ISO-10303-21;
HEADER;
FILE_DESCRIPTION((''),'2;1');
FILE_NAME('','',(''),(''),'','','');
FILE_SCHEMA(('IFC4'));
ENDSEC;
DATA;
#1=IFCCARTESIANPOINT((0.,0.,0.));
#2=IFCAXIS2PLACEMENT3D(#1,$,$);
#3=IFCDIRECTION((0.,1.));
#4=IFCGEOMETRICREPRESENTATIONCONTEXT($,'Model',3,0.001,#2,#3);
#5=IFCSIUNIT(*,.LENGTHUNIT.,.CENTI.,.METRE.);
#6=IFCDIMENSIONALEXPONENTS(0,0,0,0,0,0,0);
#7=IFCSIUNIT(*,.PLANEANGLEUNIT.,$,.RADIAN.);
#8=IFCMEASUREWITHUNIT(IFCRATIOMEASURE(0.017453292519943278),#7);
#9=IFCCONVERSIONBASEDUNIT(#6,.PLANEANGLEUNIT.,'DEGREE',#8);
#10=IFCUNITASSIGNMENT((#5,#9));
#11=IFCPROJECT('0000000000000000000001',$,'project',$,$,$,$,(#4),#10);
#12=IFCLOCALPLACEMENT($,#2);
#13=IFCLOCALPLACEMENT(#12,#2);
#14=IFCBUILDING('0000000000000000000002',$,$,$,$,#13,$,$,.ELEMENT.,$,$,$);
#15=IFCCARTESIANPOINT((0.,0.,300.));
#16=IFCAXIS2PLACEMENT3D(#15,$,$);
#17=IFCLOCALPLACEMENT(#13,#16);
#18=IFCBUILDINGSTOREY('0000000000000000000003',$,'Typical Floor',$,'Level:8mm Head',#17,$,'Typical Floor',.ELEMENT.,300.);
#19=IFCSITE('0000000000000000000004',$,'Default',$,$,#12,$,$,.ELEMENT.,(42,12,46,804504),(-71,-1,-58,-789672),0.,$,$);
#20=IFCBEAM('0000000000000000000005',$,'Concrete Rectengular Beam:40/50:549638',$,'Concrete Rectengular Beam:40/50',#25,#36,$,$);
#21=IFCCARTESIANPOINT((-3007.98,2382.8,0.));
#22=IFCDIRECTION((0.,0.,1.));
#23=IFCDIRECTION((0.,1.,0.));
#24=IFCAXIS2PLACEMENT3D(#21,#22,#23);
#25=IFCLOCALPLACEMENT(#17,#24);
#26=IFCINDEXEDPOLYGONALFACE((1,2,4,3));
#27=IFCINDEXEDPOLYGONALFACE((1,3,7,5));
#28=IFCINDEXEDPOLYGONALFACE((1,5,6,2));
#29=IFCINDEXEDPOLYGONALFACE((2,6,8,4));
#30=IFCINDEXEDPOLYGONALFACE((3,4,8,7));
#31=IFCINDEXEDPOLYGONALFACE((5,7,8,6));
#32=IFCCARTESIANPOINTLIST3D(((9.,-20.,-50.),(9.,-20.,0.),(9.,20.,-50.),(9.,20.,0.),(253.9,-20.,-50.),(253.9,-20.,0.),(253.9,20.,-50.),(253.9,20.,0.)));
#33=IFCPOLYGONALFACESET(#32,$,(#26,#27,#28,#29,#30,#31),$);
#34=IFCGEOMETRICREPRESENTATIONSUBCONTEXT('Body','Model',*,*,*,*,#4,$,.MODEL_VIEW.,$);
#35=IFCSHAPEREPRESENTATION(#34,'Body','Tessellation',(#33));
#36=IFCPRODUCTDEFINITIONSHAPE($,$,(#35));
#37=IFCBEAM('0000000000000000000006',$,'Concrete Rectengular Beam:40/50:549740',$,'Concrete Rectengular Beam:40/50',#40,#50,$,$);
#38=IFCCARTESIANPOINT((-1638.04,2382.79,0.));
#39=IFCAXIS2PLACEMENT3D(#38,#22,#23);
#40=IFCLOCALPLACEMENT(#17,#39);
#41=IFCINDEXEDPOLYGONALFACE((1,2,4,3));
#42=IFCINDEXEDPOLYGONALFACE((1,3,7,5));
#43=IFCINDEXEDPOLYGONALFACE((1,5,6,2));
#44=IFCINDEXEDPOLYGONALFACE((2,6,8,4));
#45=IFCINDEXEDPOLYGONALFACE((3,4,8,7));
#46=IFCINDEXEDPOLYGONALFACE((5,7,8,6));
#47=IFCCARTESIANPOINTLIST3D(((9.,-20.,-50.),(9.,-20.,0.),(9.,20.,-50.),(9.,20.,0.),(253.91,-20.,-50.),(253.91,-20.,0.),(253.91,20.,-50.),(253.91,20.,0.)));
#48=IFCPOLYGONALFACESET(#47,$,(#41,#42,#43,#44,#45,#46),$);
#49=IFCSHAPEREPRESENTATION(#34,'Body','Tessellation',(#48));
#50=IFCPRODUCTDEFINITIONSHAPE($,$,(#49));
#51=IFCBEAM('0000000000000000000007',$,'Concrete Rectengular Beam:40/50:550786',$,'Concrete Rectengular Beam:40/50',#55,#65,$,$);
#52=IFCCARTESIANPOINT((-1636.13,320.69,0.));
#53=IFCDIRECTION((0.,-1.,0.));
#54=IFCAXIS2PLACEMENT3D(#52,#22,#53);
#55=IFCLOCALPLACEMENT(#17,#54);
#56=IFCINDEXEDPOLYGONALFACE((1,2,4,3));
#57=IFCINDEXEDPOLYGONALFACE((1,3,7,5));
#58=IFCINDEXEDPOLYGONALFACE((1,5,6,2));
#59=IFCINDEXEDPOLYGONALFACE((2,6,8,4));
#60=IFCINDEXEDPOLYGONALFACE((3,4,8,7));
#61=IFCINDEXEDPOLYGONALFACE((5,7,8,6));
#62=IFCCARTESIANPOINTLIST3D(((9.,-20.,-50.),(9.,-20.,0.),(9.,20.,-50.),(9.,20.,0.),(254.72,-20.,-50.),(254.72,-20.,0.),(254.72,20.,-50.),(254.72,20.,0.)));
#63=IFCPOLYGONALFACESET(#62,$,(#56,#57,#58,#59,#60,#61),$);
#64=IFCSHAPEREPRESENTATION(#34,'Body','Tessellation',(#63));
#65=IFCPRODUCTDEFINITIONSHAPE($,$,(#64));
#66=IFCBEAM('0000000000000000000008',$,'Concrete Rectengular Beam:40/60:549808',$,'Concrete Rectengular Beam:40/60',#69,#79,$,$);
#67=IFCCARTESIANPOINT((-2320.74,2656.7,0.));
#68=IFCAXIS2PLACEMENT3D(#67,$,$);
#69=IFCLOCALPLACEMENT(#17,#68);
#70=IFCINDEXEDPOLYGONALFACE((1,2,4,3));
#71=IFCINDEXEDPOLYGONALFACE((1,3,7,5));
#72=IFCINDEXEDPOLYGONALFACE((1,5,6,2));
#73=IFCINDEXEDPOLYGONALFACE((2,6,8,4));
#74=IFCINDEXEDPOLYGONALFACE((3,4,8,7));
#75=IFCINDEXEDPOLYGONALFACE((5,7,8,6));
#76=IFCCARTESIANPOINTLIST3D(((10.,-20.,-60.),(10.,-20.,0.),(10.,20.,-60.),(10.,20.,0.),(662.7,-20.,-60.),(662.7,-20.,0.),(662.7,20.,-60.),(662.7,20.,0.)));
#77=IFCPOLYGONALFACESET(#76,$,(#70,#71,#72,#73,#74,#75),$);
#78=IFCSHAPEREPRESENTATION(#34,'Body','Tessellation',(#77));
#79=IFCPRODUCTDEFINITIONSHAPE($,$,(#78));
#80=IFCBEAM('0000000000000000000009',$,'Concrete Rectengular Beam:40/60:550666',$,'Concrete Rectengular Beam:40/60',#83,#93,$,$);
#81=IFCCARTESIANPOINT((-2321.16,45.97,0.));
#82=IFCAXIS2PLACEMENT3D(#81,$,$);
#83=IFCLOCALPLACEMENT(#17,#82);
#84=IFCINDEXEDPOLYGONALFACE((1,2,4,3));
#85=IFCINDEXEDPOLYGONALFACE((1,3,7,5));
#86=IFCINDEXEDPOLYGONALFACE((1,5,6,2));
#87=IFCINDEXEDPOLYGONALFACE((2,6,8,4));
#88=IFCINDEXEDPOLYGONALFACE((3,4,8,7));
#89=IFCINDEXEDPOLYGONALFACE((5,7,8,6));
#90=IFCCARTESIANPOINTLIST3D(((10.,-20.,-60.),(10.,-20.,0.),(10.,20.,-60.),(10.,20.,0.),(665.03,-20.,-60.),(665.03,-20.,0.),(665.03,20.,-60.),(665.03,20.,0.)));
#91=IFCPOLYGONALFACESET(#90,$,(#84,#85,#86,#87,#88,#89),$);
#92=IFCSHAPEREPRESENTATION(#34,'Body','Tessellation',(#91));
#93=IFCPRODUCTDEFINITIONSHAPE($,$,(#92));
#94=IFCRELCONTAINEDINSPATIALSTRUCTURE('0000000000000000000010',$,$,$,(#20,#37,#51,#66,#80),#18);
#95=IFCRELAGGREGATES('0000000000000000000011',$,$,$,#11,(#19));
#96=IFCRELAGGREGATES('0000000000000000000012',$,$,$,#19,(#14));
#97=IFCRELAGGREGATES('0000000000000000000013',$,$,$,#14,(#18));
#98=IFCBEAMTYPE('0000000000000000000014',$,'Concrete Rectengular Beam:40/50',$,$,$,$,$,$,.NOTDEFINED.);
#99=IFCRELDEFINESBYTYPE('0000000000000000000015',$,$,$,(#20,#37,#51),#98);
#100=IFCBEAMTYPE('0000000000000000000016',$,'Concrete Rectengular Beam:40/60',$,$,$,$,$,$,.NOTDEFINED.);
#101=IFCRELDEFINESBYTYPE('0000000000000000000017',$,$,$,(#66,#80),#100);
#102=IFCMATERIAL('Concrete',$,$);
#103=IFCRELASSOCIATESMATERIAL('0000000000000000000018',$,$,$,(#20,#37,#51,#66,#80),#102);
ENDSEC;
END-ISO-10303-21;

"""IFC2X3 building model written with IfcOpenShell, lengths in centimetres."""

from ifc_helpers import new_model, entity, si_unit, converted_unit, direction, frame, frame_2d, origin, origin_2d_with_axis, place, context, subcontext, project, spatial, rectangle, extrude, material, type_object, element, save


model = new_model("IFC2X3")

# Units and contexts
model_context = context("Model", 3, precision=0.001, world=origin(), true_north=direction((0.0, 1.0)))
body_context = subcontext(model_context, "Body", "Model", "MODEL_VIEW")
ifc_project = project(units=[si_unit("LENGTHUNIT", "METRE", prefix="CENTI"), converted_unit("PLANEANGLEUNIT", "DEGREE", entity("IfcRatioMeasure", 0.017453292519943278), si_unit("PLANEANGLEUNIT", "RADIAN"), dimensions=[0, 0, 0, 0, 0, 0, 0])], contexts=[model_context])

# Site, building, storey
site_placement = place(None, origin())
site = spatial("IfcSite", under=ifc_project, at=site_placement, Name="Default", CompositionType="ELEMENT", RefLatitude=(42, 12, 46, 804504), RefLongitude=(-71, -1, -58, -789672), RefElevation=0.0)
building_placement = place(site_placement, origin())
building = spatial("IfcBuilding", under=site, at=building_placement, CompositionType="ELEMENT")
storey_placement = place(building_placement, frame((0.0, 0.0, 300.0)))
storey = spatial("IfcBuildingStorey", under=building, at=storey_placement, Name="Typical Floor", ObjectType="Level:8mm Head", LongName="Typical Floor", CompositionType="ELEMENT", Elevation=300.0)

# Beams
ifc_material = material(Name="Concrete")
beam_type_1 = type_object("IfcBeamType", Name="Concrete Rectengular Beam:40/50", PredefinedType="NOTDEFINED")
beam_1_placement = place(storey_placement, frame((-3007.98, 2382.8, 0.0), z_axis=(0.0, 0.0, 1.0), x_axis=(0.0, 1.0, 0.0)))
element("IfcBeam", 1, at=beam_1_placement, inside=storey, type_object=beam_type_1, material=ifc_material, Name="Concrete Rectengular Beam:40/50:549638", ObjectType="Concrete Rectengular Beam:40/50", context=body_context, shape_type="SweptSolid", body=[
    extrude(rectangle(XDim=50.0, YDim=40.0, at=frame_2d((0.0, 0.0), x_axis=(1.0, 0.0))), frame((9.0, 0.0, -25.0), z_axis=(1.0, 0.0, 0.0), x_axis=(0.0, 0.0, -1.0)), (0.0, 0.0, 1.0), 244.9),
])
beam_2_placement = place(storey_placement, frame((-1638.04, 2382.79, 0.0), z_axis=(0.0, 0.0, 1.0), x_axis=(0.0, 1.0, 0.0)))
element("IfcBeam", 2, at=beam_2_placement, inside=storey, type_object=beam_type_1, material=ifc_material, Name="Concrete Rectengular Beam:40/50:549740", ObjectType="Concrete Rectengular Beam:40/50", context=body_context, shape_type="SweptSolid", body=[
    extrude(rectangle(XDim=50.0, YDim=40.0, at=origin_2d_with_axis()), frame((9.0, 0.0, -25.0), z_axis=(1.0, 0.0, 0.0), x_axis=(0.0, 0.0, -1.0)), (0.0, 0.0, 1.0), 244.91),
])
beam_3_placement = place(storey_placement, frame((-1636.13, 320.69, 0.0), z_axis=(0.0, 0.0, 1.0), x_axis=(0.0, -1.0, 0.0)))
element("IfcBeam", 3, at=beam_3_placement, inside=storey, type_object=beam_type_1, material=ifc_material, Name="Concrete Rectengular Beam:40/50:550786", ObjectType="Concrete Rectengular Beam:40/50", context=body_context, shape_type="SweptSolid", body=[
    extrude(rectangle(XDim=50.0, YDim=40.0, at=frame_2d((0.0, 0.0), x_axis=(1.0, 0.0))), frame((9.0, 0.0, -25.0), z_axis=(1.0, 0.0, 0.0), x_axis=(0.0, 0.0, -1.0)), (0.0, 0.0, 1.0), 245.72),
])
beam_type_2 = type_object("IfcBeamType", Name="Concrete Rectengular Beam:40/60", PredefinedType="NOTDEFINED")
beam_4_placement = place(storey_placement, frame((-2320.74, 2656.7, 0.0)))
element("IfcBeam", 4, at=beam_4_placement, inside=storey, type_object=beam_type_2, material=ifc_material, Name="Concrete Rectengular Beam:40/60:549808", ObjectType="Concrete Rectengular Beam:40/60", context=body_context, shape_type="SweptSolid", body=[
    extrude(rectangle(XDim=60.0, YDim=40.0, at=frame_2d((0.0, 0.0), x_axis=(1.0, 0.0))), frame((10.0, 0.0, -30.0), z_axis=(1.0, 0.0, 0.0), x_axis=(0.0, 0.0, -1.0)), (0.0, 0.0, 1.0), 652.7),
])
beam_5_placement = place(storey_placement, frame((-2321.16, 45.97, 0.0)))
element("IfcBeam", 5, at=beam_5_placement, inside=storey, type_object=beam_type_2, material=ifc_material, Name="Concrete Rectengular Beam:40/60:550666", ObjectType="Concrete Rectengular Beam:40/60", context=body_context, shape_type="SweptSolid", body=[
    extrude(rectangle(XDim=60.0, YDim=40.0, at=frame_2d((0.0, 0.0), x_axis=(1.0, 0.0))), frame((10.0, 0.0, -30.0), z_axis=(1.0, 0.0, 0.0), x_axis=(0.0, 0.0, -1.0)), (0.0, 0.0, 1.0), 655.03),
])

save(model, "model.ifc")
